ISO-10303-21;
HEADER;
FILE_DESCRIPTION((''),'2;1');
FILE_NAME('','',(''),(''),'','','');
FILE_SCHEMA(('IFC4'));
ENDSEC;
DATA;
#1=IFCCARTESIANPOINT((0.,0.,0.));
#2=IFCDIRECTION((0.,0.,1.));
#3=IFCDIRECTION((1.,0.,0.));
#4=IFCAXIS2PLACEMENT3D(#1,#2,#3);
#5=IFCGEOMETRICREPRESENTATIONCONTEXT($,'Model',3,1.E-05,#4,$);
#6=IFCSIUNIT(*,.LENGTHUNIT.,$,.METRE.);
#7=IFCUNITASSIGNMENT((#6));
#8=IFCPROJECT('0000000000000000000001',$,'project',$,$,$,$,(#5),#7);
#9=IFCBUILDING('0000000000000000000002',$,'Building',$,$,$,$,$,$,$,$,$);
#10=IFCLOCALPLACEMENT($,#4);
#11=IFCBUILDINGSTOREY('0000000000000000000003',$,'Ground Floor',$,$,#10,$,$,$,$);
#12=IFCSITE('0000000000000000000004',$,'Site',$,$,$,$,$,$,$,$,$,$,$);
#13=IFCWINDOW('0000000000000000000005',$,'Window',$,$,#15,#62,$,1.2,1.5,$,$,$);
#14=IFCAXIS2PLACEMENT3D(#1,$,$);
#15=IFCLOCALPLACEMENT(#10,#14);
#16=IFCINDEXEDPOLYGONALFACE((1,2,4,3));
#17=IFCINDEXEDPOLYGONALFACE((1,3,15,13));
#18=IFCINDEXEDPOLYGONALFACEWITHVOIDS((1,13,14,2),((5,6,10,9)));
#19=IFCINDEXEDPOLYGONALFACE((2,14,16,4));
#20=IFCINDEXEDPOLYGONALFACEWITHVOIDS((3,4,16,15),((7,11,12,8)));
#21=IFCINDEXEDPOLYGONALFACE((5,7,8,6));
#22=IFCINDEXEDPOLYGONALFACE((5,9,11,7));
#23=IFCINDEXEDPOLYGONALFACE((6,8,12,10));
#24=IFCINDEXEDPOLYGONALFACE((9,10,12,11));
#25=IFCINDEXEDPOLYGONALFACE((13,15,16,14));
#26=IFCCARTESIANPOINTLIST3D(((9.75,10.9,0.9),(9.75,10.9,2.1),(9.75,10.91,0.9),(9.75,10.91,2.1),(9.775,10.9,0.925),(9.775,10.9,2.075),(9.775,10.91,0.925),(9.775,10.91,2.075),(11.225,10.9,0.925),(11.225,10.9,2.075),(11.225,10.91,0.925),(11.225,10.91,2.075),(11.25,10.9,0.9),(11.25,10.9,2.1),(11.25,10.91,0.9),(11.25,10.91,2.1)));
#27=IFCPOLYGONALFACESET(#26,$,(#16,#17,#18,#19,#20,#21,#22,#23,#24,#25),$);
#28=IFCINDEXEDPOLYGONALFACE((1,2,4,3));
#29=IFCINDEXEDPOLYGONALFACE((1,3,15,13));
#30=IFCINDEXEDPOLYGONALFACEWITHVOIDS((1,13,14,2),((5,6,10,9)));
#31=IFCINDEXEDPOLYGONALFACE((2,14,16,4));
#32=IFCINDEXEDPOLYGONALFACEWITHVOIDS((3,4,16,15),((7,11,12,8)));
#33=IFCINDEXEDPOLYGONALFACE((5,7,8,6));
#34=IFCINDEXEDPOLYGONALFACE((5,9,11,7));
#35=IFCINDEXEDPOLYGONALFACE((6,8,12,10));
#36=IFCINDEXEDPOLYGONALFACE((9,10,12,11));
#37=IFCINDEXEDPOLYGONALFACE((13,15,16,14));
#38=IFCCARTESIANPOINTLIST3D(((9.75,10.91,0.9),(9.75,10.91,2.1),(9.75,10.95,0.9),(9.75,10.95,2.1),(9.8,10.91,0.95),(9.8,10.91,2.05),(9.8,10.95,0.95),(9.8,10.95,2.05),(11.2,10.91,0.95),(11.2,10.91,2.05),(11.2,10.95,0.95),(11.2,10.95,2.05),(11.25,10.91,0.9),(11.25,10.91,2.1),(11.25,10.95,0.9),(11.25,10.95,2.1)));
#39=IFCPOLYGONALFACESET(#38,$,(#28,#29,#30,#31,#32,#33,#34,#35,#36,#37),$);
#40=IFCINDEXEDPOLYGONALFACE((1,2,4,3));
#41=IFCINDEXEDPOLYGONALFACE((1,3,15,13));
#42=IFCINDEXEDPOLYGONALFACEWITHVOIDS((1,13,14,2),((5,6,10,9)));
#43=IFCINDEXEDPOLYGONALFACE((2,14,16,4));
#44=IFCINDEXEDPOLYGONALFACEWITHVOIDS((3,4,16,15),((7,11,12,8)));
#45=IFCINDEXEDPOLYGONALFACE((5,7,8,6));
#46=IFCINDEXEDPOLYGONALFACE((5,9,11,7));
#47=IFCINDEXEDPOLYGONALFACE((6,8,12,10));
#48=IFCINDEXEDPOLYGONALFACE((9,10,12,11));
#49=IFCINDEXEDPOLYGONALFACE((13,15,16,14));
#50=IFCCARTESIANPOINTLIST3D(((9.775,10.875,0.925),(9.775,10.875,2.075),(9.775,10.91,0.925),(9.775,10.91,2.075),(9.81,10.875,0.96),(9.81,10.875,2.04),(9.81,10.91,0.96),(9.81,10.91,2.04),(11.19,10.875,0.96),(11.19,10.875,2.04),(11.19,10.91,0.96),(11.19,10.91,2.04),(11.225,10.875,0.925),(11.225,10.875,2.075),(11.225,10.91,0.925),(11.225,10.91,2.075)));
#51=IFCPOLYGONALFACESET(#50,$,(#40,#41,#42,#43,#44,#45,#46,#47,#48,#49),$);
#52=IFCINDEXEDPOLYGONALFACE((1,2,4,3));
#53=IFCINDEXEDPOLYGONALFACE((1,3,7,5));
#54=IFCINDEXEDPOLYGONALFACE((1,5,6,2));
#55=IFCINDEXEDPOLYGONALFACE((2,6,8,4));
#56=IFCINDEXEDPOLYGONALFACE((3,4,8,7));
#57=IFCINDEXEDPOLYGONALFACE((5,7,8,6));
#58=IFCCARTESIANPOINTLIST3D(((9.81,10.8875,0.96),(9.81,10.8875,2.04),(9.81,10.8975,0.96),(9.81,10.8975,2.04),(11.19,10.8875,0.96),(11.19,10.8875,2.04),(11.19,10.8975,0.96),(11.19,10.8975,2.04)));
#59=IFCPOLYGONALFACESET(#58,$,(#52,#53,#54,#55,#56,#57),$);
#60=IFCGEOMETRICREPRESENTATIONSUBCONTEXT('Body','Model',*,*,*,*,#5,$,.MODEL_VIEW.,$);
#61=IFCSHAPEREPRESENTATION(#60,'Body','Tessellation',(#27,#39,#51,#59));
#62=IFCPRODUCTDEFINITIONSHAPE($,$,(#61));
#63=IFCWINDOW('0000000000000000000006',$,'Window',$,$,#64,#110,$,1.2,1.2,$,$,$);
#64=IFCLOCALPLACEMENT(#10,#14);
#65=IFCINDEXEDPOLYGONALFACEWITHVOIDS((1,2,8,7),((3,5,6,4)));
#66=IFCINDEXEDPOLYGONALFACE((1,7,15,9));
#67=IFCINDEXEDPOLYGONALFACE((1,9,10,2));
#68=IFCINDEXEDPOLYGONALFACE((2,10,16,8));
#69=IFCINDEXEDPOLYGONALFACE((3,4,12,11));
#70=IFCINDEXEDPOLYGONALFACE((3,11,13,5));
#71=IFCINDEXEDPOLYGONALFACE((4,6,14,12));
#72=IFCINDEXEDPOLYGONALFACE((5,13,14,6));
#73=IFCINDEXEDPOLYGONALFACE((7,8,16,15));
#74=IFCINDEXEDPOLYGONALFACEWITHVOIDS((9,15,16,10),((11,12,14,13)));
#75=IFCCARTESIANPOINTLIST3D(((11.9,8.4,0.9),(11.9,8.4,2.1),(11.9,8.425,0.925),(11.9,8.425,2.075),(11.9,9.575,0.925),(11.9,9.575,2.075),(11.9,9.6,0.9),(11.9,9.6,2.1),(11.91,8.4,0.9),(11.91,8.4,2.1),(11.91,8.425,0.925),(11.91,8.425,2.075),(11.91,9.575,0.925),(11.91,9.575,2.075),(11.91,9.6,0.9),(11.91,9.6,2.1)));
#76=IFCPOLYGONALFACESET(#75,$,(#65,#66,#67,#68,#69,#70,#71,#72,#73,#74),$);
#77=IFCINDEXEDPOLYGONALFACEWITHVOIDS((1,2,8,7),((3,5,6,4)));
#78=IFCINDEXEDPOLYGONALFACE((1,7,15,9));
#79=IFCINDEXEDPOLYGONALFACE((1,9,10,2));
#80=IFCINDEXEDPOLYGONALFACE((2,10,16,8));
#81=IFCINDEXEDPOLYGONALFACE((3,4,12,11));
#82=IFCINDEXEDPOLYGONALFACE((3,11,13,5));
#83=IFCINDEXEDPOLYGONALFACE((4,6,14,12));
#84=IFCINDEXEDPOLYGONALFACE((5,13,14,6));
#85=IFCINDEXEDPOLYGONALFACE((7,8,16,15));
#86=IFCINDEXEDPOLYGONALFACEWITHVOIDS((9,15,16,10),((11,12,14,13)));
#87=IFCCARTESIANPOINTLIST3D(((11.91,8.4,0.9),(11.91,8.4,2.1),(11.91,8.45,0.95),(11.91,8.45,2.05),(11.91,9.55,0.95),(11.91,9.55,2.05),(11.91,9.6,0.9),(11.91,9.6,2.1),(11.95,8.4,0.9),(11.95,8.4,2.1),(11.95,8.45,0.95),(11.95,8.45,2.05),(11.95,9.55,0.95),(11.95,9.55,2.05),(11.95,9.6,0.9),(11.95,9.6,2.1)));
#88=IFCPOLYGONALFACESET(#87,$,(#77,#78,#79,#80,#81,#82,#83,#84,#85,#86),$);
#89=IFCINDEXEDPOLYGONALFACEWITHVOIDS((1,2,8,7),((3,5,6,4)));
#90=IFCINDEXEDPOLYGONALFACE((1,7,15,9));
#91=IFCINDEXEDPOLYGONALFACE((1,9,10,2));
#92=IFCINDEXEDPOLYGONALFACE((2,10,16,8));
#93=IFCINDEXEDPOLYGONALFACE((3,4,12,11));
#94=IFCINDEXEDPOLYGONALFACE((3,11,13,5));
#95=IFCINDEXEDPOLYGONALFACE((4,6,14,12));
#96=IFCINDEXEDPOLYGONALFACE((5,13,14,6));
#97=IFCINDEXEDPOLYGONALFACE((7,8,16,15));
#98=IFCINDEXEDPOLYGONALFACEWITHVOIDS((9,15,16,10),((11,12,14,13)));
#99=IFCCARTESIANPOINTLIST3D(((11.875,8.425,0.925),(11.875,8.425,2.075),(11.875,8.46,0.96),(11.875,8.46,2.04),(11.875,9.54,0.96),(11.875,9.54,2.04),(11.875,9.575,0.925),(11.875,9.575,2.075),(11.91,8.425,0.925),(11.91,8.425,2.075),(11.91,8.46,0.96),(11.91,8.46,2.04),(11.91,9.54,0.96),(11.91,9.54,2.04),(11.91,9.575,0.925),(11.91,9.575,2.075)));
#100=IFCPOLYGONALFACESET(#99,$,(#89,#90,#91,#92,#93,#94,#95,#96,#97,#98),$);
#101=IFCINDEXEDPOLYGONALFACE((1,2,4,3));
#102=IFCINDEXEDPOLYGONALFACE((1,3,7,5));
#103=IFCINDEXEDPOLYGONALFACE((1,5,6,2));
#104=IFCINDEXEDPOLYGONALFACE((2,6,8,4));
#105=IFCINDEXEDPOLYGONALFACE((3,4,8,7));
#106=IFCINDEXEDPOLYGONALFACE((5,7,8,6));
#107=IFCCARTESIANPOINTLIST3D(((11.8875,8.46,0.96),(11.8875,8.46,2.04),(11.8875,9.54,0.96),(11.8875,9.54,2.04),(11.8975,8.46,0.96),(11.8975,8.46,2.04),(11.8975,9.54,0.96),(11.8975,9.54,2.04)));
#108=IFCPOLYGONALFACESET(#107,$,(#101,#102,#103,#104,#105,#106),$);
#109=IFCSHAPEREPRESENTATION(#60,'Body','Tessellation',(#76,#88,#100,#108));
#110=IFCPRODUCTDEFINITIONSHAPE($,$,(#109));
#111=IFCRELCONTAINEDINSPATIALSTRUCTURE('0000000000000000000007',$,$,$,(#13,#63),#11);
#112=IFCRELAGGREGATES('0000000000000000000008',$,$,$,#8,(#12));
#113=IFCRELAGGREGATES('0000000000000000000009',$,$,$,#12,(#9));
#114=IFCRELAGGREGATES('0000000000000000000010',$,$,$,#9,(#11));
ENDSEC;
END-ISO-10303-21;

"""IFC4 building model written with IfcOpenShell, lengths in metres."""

from ifc_helpers import new_model, si_unit, frame, origin_with_axes, place, context, subcontext, project, spatial, line, indexed_curve, outline, extrude, element, save


model = new_model("IFC4")

# Units and contexts
model_context = context("Model", 3, precision=1e-05, world=origin_with_axes())
body_context = subcontext(model_context, "Body", "Model", "MODEL_VIEW")
ifc_project = project(units=[si_unit("LENGTHUNIT", "METRE")], contexts=[model_context])

# Site, building, storey
site = spatial("IfcSite", under=ifc_project, Name="Site")
building = spatial("IfcBuilding", under=site, Name="Building")
storey_placement = place(None, origin_with_axes())
storey = spatial("IfcBuildingStorey", under=building, at=storey_placement, Name="Ground Floor")

# Windows
for number, where, z_axis, x_axis, name in (
    (1, (11.25, 11.0, 0.9), (0.0, 0.0, 1.0), (-1.0, 0.0, 0.0), "Window"),
):
    element("IfcWindow", number, at=place(storey_placement, frame(where, z_axis=z_axis, x_axis=x_axis)), inside=storey, Name=name, OverallHeight=1.2, OverallWidth=1.5, context=body_context, shape_type="SweptSolid", body=[
        extrude(outline(indexed_curve([(0.0, 0.0), (1.5, 0.0), (1.5, 1.2), (0.0, 1.2)], segments=[line(1, 2, 3, 4, 1)]), holes=[indexed_curve([(0.025, 0.025), (1.475, 0.025), (1.475, 1.175), (0.025, 1.175)], segments=[line(1, 2, 3, 4, 1)])]), frame((0.0, 0.09, 0.0), z_axis=(0.0, -1.0, 0.0), x_axis=(1.0, 0.0, 0.0)), (0.0, 0.0, -1.0), 0.01),
        extrude(outline(indexed_curve([(0.0, 0.0), (1.5, 0.0), (1.5, 1.2), (0.0, 1.2)], segments=[line(1, 2, 3, 4, 1)]), holes=[indexed_curve([(0.05, 0.05), (1.45, 0.05), (1.45, 1.15), (0.05, 1.15)], segments=[line(1, 2, 3, 4, 1)])]), frame((0.0, 0.05, 0.0), z_axis=(0.0, -1.0, 0.0), x_axis=(1.0, 0.0, 0.0)), (0.0, 0.0, -1.0), 0.04),
        extrude(outline(indexed_curve([(0.0, 0.0), (1.45, 0.0), (1.45, 1.15), (0.0, 1.15)], segments=[line(1, 2, 3, 4, 1)]), holes=[indexed_curve([(0.035, 0.035), (1.415, 0.035), (1.415, 1.115), (0.035, 1.115)], segments=[line(1, 2, 3, 4, 1)])]), frame((0.025, 0.09, 0.025), z_axis=(0.0, -1.0, 0.0), x_axis=(1.0, 0.0, 0.0)), (0.0, 0.0, -1.0), 0.035),
        extrude(outline(indexed_curve([(0.035, 0.035), (1.415, 0.035), (1.415, 1.115), (0.035, 1.115)], segments=[line(1, 2, 3, 4, 1)])), frame((0.025, 0.1025, 0.025), z_axis=(0.0, -1.0, 0.0), x_axis=(1.0, 0.0, 0.0)), (0.0, 0.0, -1.0), 0.01),
    ])
window_1_placement = place(storey_placement, frame((12.0, 8.4, 0.9), z_axis=(0.0, 0.0, 1.0), x_axis=(0.0, 1.0, 0.0)))
element("IfcWindow", 2, at=window_1_placement, inside=storey, Name="Window", OverallHeight=1.2, OverallWidth=1.2, context=body_context, shape_type="SweptSolid", body=[
    extrude(outline(indexed_curve([(0.0, 0.0), (1.2, 0.0), (1.2, 1.2), (0.0, 1.2)], segments=[line(1, 2, 3, 4, 1)]), holes=[indexed_curve([(0.025, 0.025), (1.175, 0.025), (1.175, 1.175), (0.025, 1.175)], segments=[line(1, 2, 3, 4, 1)])]), frame((0.0, 0.09, 0.0), z_axis=(0.0, -1.0, 0.0), x_axis=(1.0, 0.0, 0.0)), (0.0, 0.0, -1.0), 0.01),
    extrude(outline(indexed_curve([(0.0, 0.0), (1.2, 0.0), (1.2, 1.2), (0.0, 1.2)], segments=[line(1, 2, 3, 4, 1)]), holes=[indexed_curve([(0.05, 0.05), (1.15, 0.05), (1.15, 1.15), (0.05, 1.15)], segments=[line(1, 2, 3, 4, 1)])]), frame((0.0, 0.05, 0.0), z_axis=(0.0, -1.0, 0.0), x_axis=(1.0, 0.0, 0.0)), (0.0, 0.0, -1.0), 0.04),
    extrude(outline(indexed_curve([(0.0, 0.0), (1.15, 0.0), (1.15, 1.15), (0.0, 1.15)], segments=[line(1, 2, 3, 4, 1)]), holes=[indexed_curve([(0.035, 0.035), (1.115, 0.035), (1.115, 1.115), (0.035, 1.115)], segments=[line(1, 2, 3, 4, 1)])]), frame((0.025, 0.09, 0.025), z_axis=(0.0, -1.0, 0.0), x_axis=(1.0, 0.0, 0.0)), (0.0, 0.0, -1.0), 0.035),
    extrude(outline(indexed_curve([(0.035, 0.035), (1.115, 0.035), (1.115, 1.115), (0.035, 1.115)], segments=[line(1, 2, 3, 4, 1)])), frame((0.025, 0.1025, 0.025), z_axis=(0.0, -1.0, 0.0), x_axis=(1.0, 0.0, 0.0)), (0.0, 0.0, -1.0), 0.01),
])

save(model, "model.ifc")
